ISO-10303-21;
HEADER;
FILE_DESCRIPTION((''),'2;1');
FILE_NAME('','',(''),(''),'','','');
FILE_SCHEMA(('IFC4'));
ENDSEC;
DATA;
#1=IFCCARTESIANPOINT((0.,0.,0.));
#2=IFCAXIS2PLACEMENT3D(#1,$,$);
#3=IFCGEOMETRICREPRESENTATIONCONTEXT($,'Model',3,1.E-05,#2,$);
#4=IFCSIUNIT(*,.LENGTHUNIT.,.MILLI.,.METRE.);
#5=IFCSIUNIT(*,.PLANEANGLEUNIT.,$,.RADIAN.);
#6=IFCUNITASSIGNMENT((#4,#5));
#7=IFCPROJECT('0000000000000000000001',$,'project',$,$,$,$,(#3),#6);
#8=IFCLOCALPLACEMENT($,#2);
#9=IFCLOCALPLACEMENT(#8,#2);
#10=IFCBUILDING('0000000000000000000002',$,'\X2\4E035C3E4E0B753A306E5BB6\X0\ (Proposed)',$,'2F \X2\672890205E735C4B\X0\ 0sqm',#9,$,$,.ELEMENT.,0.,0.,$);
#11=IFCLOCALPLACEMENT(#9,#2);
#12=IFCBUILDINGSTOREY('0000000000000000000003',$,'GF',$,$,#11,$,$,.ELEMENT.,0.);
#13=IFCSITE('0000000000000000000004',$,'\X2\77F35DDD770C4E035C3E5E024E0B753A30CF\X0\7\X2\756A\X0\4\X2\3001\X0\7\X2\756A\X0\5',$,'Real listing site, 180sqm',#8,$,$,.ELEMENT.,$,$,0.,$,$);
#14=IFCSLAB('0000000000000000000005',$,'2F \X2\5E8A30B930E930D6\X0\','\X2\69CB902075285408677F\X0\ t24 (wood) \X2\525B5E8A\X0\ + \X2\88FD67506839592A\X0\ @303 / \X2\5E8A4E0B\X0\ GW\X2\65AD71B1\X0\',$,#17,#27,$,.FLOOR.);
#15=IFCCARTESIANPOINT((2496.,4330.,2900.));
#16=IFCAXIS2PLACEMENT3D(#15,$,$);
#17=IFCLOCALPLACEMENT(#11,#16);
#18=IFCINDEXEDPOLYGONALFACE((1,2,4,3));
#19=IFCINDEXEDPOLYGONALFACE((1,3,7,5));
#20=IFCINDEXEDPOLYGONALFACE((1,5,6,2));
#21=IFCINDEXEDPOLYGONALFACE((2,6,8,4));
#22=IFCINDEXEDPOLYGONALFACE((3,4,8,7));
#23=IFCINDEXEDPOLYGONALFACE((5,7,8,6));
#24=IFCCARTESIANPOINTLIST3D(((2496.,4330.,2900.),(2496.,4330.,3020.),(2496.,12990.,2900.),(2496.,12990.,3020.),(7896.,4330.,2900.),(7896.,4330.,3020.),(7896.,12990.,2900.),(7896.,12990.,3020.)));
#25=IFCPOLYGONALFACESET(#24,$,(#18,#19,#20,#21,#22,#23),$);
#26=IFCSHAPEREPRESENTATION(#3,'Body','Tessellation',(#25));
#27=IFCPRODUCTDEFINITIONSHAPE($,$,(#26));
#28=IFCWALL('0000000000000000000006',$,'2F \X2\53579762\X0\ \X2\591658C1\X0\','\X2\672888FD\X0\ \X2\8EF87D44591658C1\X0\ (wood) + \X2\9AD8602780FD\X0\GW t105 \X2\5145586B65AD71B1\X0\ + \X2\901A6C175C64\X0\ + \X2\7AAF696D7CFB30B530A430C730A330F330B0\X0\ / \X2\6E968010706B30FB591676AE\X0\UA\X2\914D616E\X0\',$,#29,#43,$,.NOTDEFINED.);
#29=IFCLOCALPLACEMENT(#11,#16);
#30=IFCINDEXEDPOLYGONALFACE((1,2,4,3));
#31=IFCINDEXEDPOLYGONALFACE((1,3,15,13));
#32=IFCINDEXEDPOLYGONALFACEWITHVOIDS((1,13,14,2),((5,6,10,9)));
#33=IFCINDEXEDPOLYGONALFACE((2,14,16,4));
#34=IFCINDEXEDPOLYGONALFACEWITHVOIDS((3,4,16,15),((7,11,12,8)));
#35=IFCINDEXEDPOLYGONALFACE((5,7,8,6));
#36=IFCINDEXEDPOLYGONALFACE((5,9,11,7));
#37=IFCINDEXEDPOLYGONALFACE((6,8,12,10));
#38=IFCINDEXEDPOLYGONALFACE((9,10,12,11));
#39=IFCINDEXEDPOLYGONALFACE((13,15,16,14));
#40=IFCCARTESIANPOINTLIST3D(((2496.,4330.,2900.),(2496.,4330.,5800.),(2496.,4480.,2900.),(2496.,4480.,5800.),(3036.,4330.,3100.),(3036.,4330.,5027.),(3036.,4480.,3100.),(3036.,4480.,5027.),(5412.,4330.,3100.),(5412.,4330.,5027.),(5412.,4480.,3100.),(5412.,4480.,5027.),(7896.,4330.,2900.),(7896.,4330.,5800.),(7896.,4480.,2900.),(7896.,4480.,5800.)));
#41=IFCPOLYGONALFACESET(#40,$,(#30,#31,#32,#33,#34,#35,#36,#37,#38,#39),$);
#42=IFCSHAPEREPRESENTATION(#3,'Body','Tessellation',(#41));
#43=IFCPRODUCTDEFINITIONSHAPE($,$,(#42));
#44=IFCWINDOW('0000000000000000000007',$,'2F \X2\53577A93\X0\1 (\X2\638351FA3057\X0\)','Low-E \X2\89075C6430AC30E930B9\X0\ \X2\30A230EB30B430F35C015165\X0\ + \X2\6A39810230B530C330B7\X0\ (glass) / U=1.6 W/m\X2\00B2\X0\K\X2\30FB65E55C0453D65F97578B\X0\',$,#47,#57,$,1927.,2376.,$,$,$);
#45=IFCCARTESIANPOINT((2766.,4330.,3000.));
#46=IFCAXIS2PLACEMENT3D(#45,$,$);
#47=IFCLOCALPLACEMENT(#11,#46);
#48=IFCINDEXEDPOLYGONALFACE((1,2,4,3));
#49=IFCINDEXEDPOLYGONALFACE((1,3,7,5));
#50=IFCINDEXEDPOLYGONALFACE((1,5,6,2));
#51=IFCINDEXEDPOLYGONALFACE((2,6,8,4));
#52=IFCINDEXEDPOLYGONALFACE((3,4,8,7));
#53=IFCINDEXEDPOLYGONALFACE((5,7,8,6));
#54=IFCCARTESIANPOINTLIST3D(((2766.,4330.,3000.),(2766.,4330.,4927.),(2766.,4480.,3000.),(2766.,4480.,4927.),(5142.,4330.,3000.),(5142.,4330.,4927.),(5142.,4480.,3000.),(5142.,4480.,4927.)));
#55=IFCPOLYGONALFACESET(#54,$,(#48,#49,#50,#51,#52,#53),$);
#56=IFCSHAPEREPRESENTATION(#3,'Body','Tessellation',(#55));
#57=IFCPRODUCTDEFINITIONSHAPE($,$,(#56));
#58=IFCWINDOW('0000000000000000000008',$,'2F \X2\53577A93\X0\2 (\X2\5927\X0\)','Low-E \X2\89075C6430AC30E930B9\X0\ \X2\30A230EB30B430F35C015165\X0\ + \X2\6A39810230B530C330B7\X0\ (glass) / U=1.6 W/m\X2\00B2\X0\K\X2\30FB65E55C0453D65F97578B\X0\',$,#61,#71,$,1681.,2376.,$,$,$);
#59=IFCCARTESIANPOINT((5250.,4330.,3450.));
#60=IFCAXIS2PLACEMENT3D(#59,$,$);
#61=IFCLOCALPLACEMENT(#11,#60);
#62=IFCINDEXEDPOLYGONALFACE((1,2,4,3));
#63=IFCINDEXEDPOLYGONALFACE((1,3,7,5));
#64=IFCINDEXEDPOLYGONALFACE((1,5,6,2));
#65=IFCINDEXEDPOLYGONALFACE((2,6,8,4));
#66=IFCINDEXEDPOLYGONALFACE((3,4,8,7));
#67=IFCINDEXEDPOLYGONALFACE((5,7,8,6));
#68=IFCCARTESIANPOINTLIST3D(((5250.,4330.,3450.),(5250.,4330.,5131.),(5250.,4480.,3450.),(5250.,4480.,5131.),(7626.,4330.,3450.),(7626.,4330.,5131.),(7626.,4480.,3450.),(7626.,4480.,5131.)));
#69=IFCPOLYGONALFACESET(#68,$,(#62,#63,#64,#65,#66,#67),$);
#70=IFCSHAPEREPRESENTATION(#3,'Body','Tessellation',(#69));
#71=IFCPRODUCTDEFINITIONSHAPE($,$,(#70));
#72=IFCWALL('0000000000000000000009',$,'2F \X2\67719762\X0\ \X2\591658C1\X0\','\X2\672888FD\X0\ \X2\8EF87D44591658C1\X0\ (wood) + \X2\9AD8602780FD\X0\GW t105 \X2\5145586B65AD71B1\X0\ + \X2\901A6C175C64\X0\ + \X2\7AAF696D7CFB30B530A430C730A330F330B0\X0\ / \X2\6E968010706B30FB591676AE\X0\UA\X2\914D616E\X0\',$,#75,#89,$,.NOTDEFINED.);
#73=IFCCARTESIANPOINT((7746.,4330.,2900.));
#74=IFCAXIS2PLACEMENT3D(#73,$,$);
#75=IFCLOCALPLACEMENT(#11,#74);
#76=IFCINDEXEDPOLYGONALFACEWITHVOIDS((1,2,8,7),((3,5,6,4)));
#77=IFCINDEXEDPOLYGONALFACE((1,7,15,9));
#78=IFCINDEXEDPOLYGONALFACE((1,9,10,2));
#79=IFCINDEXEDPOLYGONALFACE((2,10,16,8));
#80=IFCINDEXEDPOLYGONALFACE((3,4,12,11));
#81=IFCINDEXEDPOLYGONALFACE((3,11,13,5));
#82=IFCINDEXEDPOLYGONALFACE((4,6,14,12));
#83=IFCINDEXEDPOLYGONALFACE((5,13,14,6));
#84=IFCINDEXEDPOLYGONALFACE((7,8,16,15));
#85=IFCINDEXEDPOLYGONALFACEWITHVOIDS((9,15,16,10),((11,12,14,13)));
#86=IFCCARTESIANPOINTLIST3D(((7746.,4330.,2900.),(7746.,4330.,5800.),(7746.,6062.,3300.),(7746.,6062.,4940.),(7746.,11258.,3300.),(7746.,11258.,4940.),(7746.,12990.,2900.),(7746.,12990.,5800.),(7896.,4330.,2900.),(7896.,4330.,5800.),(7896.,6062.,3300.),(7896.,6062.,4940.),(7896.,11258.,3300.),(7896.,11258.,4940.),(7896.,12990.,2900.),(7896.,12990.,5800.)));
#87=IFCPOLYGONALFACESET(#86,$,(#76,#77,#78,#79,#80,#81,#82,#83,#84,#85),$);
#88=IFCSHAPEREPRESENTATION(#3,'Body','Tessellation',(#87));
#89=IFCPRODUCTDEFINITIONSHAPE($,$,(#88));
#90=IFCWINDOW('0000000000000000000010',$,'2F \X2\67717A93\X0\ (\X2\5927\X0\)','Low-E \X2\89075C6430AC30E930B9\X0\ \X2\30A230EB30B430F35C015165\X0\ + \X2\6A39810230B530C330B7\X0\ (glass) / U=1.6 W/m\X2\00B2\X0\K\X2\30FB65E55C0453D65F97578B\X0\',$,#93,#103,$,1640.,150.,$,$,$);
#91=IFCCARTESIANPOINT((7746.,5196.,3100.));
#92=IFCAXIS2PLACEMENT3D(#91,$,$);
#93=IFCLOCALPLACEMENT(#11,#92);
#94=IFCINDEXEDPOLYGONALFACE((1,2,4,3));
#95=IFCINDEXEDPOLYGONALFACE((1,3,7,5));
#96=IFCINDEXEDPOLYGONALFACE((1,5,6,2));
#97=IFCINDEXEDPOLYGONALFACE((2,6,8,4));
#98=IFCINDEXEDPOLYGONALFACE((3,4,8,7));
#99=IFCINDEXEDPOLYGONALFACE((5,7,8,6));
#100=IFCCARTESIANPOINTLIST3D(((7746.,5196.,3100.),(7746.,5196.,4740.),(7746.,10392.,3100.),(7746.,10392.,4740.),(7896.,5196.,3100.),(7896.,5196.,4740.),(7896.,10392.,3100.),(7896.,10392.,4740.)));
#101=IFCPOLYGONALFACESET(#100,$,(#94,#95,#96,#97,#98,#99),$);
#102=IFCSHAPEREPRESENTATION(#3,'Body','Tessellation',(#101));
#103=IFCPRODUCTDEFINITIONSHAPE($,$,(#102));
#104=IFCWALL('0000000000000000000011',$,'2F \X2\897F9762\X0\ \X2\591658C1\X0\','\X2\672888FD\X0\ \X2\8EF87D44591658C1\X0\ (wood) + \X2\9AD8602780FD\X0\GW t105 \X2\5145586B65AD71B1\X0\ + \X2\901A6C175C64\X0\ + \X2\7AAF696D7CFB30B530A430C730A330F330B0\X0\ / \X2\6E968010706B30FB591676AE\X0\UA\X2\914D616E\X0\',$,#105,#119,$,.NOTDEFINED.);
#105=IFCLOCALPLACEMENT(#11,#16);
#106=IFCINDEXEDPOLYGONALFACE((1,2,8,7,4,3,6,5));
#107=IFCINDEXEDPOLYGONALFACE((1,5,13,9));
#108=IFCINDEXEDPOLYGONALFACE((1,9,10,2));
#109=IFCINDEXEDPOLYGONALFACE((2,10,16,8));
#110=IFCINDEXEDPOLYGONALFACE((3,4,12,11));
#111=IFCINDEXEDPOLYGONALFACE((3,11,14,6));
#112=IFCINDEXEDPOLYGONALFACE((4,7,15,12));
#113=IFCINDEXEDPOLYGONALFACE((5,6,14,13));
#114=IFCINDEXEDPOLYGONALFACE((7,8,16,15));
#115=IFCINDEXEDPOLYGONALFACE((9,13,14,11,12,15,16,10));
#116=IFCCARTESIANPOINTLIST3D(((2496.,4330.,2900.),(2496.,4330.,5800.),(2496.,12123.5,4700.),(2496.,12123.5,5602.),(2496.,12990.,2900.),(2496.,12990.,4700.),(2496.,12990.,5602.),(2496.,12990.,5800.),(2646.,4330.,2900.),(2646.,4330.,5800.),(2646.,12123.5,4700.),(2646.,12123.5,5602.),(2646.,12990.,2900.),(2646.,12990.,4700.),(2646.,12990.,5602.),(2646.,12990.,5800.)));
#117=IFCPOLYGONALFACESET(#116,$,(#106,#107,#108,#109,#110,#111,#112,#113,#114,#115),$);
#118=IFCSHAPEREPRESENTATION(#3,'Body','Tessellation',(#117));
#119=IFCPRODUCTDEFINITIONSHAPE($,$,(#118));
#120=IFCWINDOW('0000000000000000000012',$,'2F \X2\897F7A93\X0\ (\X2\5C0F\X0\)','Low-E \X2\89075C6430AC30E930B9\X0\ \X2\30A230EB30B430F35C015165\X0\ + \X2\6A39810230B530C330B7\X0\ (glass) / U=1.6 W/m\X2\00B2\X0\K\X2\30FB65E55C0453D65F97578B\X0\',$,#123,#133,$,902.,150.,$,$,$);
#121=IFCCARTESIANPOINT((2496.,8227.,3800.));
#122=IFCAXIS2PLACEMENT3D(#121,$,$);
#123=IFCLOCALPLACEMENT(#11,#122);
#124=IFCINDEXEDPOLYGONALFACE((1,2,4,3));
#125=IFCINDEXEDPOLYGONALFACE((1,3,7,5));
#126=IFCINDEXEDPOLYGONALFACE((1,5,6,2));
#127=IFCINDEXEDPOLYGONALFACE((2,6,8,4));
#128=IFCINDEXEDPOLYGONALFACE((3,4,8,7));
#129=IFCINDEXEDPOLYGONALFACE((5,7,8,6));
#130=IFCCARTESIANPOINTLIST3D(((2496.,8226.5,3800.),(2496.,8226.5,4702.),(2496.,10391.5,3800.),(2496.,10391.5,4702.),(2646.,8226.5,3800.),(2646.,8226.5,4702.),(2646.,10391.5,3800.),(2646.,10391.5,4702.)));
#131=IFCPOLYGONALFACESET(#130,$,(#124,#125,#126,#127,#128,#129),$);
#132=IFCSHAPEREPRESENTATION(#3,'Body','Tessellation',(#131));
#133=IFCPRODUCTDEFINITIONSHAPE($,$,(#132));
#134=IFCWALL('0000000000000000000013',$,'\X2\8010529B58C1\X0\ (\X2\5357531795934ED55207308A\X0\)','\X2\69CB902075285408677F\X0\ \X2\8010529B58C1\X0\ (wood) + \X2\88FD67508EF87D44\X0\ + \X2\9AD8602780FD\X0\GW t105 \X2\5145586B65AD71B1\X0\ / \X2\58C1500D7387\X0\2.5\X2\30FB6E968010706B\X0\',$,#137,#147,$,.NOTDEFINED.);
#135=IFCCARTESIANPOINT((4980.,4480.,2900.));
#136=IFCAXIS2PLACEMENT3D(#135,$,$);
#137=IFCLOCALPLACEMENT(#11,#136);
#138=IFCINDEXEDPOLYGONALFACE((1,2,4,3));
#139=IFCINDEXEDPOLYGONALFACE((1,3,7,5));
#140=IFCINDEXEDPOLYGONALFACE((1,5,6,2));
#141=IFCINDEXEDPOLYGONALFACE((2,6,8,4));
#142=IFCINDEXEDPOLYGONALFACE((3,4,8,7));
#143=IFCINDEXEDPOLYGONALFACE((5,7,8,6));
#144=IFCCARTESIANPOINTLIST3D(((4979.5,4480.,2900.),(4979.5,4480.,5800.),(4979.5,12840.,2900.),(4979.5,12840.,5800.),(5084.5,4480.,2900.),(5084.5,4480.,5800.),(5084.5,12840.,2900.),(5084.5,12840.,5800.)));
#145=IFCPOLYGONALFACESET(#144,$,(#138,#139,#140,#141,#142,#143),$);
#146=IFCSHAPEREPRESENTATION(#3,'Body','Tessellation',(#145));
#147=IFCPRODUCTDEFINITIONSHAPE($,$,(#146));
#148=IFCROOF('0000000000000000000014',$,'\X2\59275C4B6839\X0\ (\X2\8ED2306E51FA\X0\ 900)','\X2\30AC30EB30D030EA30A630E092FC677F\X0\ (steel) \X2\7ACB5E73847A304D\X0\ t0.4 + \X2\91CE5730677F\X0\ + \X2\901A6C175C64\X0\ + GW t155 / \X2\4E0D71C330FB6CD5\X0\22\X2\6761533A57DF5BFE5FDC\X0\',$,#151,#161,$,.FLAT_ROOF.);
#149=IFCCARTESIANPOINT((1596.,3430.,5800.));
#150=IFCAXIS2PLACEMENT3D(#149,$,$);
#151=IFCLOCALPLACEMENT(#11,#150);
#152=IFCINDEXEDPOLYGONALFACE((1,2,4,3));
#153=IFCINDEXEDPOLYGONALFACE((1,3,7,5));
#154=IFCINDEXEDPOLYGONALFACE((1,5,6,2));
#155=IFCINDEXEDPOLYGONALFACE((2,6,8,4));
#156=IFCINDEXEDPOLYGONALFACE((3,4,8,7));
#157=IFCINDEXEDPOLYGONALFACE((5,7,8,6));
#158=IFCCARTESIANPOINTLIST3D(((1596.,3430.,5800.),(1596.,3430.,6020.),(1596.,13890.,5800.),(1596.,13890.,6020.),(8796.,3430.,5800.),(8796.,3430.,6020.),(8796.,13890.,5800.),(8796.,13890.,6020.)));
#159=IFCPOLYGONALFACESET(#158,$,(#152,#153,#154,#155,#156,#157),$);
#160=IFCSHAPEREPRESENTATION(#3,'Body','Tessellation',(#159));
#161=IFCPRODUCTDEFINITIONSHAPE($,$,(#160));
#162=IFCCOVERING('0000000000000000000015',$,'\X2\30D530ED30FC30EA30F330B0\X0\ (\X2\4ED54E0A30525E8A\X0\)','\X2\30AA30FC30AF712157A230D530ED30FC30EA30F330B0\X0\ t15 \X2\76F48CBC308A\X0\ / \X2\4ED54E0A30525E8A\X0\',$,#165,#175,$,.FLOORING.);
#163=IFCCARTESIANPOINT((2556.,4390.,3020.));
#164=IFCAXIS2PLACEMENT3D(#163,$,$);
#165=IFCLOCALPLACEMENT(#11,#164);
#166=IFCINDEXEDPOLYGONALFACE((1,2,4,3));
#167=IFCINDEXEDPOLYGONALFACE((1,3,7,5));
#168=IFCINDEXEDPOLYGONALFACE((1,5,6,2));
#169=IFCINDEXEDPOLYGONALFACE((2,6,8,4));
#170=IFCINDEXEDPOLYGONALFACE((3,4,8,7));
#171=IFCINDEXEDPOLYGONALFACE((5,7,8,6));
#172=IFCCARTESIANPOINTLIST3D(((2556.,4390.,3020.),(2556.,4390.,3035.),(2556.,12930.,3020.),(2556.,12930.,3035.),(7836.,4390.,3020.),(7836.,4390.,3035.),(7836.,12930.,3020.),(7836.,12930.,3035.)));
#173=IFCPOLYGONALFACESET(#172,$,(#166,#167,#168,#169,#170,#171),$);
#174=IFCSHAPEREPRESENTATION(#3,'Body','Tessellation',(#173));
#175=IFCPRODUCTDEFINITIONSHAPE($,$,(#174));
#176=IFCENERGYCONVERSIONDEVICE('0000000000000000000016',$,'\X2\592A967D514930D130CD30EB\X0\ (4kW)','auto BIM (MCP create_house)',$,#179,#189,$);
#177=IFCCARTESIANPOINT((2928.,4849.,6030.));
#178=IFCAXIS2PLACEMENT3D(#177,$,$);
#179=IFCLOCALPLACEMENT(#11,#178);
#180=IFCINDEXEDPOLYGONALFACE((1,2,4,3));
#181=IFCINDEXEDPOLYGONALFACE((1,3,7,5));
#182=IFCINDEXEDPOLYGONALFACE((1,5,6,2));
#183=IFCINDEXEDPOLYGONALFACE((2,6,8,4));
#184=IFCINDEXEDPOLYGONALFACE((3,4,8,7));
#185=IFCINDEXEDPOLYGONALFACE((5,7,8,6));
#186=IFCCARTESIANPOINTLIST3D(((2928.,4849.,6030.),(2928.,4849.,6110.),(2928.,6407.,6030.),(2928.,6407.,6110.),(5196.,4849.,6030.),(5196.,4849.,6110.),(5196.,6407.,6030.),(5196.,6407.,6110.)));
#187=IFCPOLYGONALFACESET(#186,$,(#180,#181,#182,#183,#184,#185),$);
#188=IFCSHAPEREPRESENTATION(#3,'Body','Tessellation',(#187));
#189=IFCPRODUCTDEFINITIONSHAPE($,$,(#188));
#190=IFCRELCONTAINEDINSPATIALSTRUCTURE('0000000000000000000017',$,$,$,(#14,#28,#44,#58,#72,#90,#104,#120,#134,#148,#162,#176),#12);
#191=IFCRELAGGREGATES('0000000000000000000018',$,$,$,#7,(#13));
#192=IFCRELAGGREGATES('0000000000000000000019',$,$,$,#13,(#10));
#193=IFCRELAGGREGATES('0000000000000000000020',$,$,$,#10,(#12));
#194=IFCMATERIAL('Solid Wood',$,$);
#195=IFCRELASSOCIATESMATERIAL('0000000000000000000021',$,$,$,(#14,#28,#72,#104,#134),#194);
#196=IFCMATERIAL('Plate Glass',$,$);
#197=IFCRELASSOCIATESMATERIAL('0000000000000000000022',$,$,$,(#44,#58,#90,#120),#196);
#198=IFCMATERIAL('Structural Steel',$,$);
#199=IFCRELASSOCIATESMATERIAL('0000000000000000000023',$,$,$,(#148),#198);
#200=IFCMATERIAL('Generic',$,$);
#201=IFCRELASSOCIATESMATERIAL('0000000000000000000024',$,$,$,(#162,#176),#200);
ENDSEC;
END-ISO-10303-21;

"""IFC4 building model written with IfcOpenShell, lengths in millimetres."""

from ifc_helpers import new_model, si_unit, frame, frame_2d, origin, place, context, project, spatial, rectangle, extrude, material, element, fill, save


model = new_model("IFC4")

# Units and contexts
model_context = context("Model", 3, precision=1e-05, world=origin())
ifc_project = project(units=[si_unit("LENGTHUNIT", "METRE", prefix="MILLI"), si_unit("PLANEANGLEUNIT", "RADIAN")], contexts=[model_context])

# Site, building, storey
site_placement = place(None, origin())
site = spatial("IfcSite", under=ifc_project, at=site_placement, Name="石川県七尾市下町ハ7番4、7番5", ObjectType="Real listing site, 180sqm", CompositionType="ELEMENT", RefElevation=0.0)
building_placement = place(site_placement, origin())
building = spatial("IfcBuilding", under=site, at=building_placement, Name="七尾下町の家 (Proposed)", ObjectType="2F 木造平屋 0sqm", CompositionType="ELEMENT", ElevationOfRefHeight=0.0, ElevationOfTerrain=0.0)
storey_placement = place(building_placement, origin())
storey = spatial("IfcBuildingStorey", under=building, at=storey_placement, Name="GF", CompositionType="ELEMENT", Elevation=0.0)

# Slab
ifc_material_1 = material(Name="Solid Wood")
slab_placement = place(storey_placement, frame((2496.0, 4330.0, 2900.0)))
element("IfcSlab", 1, at=slab_placement, inside=storey, material=ifc_material_1, Name="2F 床スラブ", Description="構造用合板 t24 (wood) 剛床 + 製材根太 @303 / 床下 GW断熱", PredefinedType="FLOOR", context=model_context, shape_type="SweptSolid", body=[
    extrude(rectangle(XDim=5400.0, YDim=8660.0, at=frame_2d((2700.0, 4330.0))), frame((2496.0, 4330.0, 2900.0)), (0.0, 0.0, 1.0), 120.0),
])

# Wall, openings, windows
wall_1_placement = place(storey_placement, frame((2496.0, 4330.0, 2900.0)))
wall_1 = element("IfcWall", 2, at=wall_1_placement, inside=storey, material=ifc_material_1, Name="2F 南面 外壁", Description="木製 軸組外壁 (wood) + 高性能GW t105 充填断熱 + 通気層 + 窯業系サイディング / 準耐火・外皮UA配慮", PredefinedType="NOTDEFINED", context=model_context, shape_type="SweptSolid", body=[
    extrude(rectangle(XDim=5400.0, YDim=150.0, at=frame_2d((2700.0, 75.0))), frame((2496.0, 4330.0, 2900.0)), (0.0, 0.0, 1.0), 2900.0),
])
opening_1_placement = place(storey_placement, frame((2766.0, 4330.0, 3000.0)))
opening_1 = element("IfcOpeningElement", 3, at=opening_1_placement, cuts=wall_1, PredefinedType="NOTDEFINED", context=model_context, shape_type="SweptSolid", body=[
    extrude(rectangle(XDim=2376.0, YDim=150.0, at=frame_2d((1188.0, 75.0))), frame((2766.0, 4330.0, 3000.0)), (0.0, 0.0, 1.0), 1927.0),
])
opening_2_placement = place(storey_placement, frame((5250.0, 4330.0, 3450.0)))
opening_2 = element("IfcOpeningElement", 4, at=opening_2_placement, cuts=wall_1, PredefinedType="NOTDEFINED", context=model_context, shape_type="SweptSolid", body=[
    extrude(rectangle(XDim=2376.0, YDim=150.0, at=frame_2d((1188.0, 75.0))), frame((5250.0, 4330.0, 3450.0)), (0.0, 0.0, 1.0), 1681.0),
])
ifc_material_2 = material(Name="Plate Glass")
window_1_placement = place(storey_placement, frame((2766.0, 4330.0, 3000.0)))
window_1 = element("IfcWindow", 5, at=window_1_placement, inside=storey, material=ifc_material_2, Name="2F 南窓1 (掃出し)", Description="Low-E 複層ガラス アルゴン封入 + 樹脂サッシ (glass) / U=1.6 W/m²K・日射取得型", OverallHeight=1927.0, OverallWidth=2376.0, context=model_context, shape_type="SweptSolid", body=[
    extrude(rectangle(XDim=2376.0, YDim=150.0, at=frame_2d((1188.0, 75.0))), frame((2766.0, 4330.0, 3000.0)), (0.0, 0.0, 1.0), 1927.0),
])
fill(opening_1, window_1)
window_2_placement = place(storey_placement, frame((5250.0, 4330.0, 3450.0)))
window_2 = element("IfcWindow", 6, at=window_2_placement, inside=storey, material=ifc_material_2, Name="2F 南窓2 (大)", Description="Low-E 複層ガラス アルゴン封入 + 樹脂サッシ (glass) / U=1.6 W/m²K・日射取得型", OverallHeight=1681.0, OverallWidth=2376.0, context=model_context, shape_type="SweptSolid", body=[
    extrude(rectangle(XDim=2376.0, YDim=150.0, at=frame_2d((1188.0, 75.0))), frame((5250.0, 4330.0, 3450.0)), (0.0, 0.0, 1.0), 1681.0),
])
fill(opening_2, window_2)

# Walls, openings, windows
wall_2_placement = place(storey_placement, frame((7746.0, 4330.0, 2900.0)))
wall_2 = element("IfcWall", 7, at=wall_2_placement, inside=storey, material=ifc_material_1, Name="2F 東面 外壁", Description="木製 軸組外壁 (wood) + 高性能GW t105 充填断熱 + 通気層 + 窯業系サイディング / 準耐火・外皮UA配慮", PredefinedType="NOTDEFINED", context=model_context, shape_type="SweptSolid", body=[
    extrude(rectangle(XDim=150.0, YDim=8660.0, at=frame_2d((75.0, 4330.0))), frame((7746.0, 4330.0, 2900.0)), (0.0, 0.0, 1.0), 2900.0),
])
opening_3_placement = place(storey_placement, frame((7746.0, 5196.0, 3100.0)))
opening_3 = element("IfcOpeningElement", 8, at=opening_3_placement, cuts=wall_2, PredefinedType="NOTDEFINED", context=model_context, shape_type="SweptSolid", body=[
    extrude(rectangle(XDim=150.0, YDim=5196.0, at=frame_2d((75.0, 2598.0))), frame((7746.0, 5196.0, 3100.0)), (0.0, 0.0, 1.0), 1640.0),
])
window_3_placement = place(storey_placement, frame((7746.0, 5196.0, 3100.0)))
window_3 = element("IfcWindow", 9, at=window_3_placement, inside=storey, material=ifc_material_2, Name="2F 東窓 (大)", Description="Low-E 複層ガラス アルゴン封入 + 樹脂サッシ (glass) / U=1.6 W/m²K・日射取得型", OverallHeight=1640.0, OverallWidth=150.0, context=model_context, shape_type="SweptSolid", body=[
    extrude(rectangle(XDim=150.0, YDim=5196.0, at=frame_2d((75.0, 2598.0))), frame((7746.0, 5196.0, 3100.0)), (0.0, 0.0, 1.0), 1640.0),
])
fill(opening_3, window_3)
wall_3_placement = place(storey_placement, frame((2496.0, 4330.0, 2900.0)))
wall_3 = element("IfcWall", 10, at=wall_3_placement, inside=storey, material=ifc_material_1, Name="2F 西面 外壁", Description="木製 軸組外壁 (wood) + 高性能GW t105 充填断熱 + 通気層 + 窯業系サイディング / 準耐火・外皮UA配慮", PredefinedType="NOTDEFINED", context=model_context, shape_type="SweptSolid", body=[
    extrude(rectangle(XDim=150.0, YDim=8660.0, at=frame_2d((75.0, 4330.0))), frame((2496.0, 4330.0, 2900.0)), (0.0, 0.0, 1.0), 2900.0),
])
opening_4_placement = place(storey_placement, frame((2496.0, 8227.0, 3800.0)))
opening_4 = element("IfcOpeningElement", 11, at=opening_4_placement, cuts=wall_3, PredefinedType="NOTDEFINED", context=model_context, shape_type="SweptSolid", body=[
    extrude(rectangle(XDim=150.0, YDim=2165.0, at=frame_2d((75.0, 1082.0))), frame((2496.0, 8227.0, 3800.0)), (0.0, 0.0, 1.0), 902.0),
])
window_4_placement = place(storey_placement, frame((2496.0, 8227.0, 3800.0)))
window_4 = element("IfcWindow", 12, at=window_4_placement, inside=storey, material=ifc_material_2, Name="2F 西窓 (小)", Description="Low-E 複層ガラス アルゴン封入 + 樹脂サッシ (glass) / U=1.6 W/m²K・日射取得型", OverallHeight=902.0, OverallWidth=150.0, context=model_context, shape_type="SweptSolid", body=[
    extrude(rectangle(XDim=150.0, YDim=2165.0, at=frame_2d((75.0, 1082.0))), frame((2496.0, 8227.0, 3800.0)), (0.0, 0.0, 1.0), 902.0),
])
fill(opening_4, window_4)

# Wall
wall_4_placement = place(storey_placement, frame((4980.0, 4480.0, 2900.0)))
element("IfcWall", 13, at=wall_4_placement, inside=storey, material=ifc_material_1, Name="耐力壁 (南北間仕切り)", Description="構造用合板 耐力壁 (wood) + 製材軸組 + 高性能GW t105 充填断熱 / 壁倍率2.5・準耐火", PredefinedType="NOTDEFINED", context=model_context, shape_type="SweptSolid", body=[
    extrude(rectangle(XDim=105.0, YDim=8360.0, at=frame_2d((52.0, 4180.0))), frame((4980.0, 4480.0, 2900.0)), (0.0, 0.0, 1.0), 2900.0),
])

# Roof
ifc_material_3 = material(Name="Structural Steel")
roof_placement = place(storey_placement, frame((1596.0, 3430.0, 5800.0)))
element("IfcRoof", 14, at=roof_placement, inside=storey, material=ifc_material_3, Name="大屋根 (軒の出 900)", Description="ガルバリウム鋼板 (steel) 立平葺き t0.4 + 野地板 + 通気層 + GW t155 / 不燃・法22条区域対応", PredefinedType="FLAT_ROOF", context=model_context, shape_type="SweptSolid", body=[
    extrude(rectangle(XDim=7200.0, YDim=10460.0, at=frame_2d((3600.0, 5230.0))), frame((1596.0, 3430.0, 5800.0)), (0.0, 0.0, 1.0), 220.0),
])

# Covering
ifc_material_4 = material(Name="Generic")
covering_placement = place(storey_placement, frame((2556.0, 4390.0, 3020.0)))
element("IfcCovering", 15, at=covering_placement, inside=storey, material=ifc_material_4, Name="フローリング (仕上げ床)", Description="オーク無垢フローリング t15 直貼り / 仕上げ床", PredefinedType="FLOORING", context=model_context, shape_type="SweptSolid", body=[
    extrude(rectangle(XDim=5280.0, YDim=8540.0, at=frame_2d((2640.0, 4270.0))), frame((2556.0, 4390.0, 3020.0)), (0.0, 0.0, 1.0), 15.0),
])

# Energy conversion device
energy_conversion_device_placement = place(storey_placement, frame((2928.0, 4849.0, 6030.0)))
element("IfcEnergyConversionDevice", 16, at=energy_conversion_device_placement, inside=storey, material=ifc_material_4, Name="太陽光パネル (4kW)", Description="auto BIM (MCP create_house)", context=model_context, shape_type="SweptSolid", body=[
    extrude(rectangle(XDim=2268.0, YDim=1558.0, at=frame_2d((1134.0, 779.0))), frame((2928.0, 4849.0, 6030.0)), (0.0, 0.0, 1.0), 80.0),
])

save(model, "model.ifc")
